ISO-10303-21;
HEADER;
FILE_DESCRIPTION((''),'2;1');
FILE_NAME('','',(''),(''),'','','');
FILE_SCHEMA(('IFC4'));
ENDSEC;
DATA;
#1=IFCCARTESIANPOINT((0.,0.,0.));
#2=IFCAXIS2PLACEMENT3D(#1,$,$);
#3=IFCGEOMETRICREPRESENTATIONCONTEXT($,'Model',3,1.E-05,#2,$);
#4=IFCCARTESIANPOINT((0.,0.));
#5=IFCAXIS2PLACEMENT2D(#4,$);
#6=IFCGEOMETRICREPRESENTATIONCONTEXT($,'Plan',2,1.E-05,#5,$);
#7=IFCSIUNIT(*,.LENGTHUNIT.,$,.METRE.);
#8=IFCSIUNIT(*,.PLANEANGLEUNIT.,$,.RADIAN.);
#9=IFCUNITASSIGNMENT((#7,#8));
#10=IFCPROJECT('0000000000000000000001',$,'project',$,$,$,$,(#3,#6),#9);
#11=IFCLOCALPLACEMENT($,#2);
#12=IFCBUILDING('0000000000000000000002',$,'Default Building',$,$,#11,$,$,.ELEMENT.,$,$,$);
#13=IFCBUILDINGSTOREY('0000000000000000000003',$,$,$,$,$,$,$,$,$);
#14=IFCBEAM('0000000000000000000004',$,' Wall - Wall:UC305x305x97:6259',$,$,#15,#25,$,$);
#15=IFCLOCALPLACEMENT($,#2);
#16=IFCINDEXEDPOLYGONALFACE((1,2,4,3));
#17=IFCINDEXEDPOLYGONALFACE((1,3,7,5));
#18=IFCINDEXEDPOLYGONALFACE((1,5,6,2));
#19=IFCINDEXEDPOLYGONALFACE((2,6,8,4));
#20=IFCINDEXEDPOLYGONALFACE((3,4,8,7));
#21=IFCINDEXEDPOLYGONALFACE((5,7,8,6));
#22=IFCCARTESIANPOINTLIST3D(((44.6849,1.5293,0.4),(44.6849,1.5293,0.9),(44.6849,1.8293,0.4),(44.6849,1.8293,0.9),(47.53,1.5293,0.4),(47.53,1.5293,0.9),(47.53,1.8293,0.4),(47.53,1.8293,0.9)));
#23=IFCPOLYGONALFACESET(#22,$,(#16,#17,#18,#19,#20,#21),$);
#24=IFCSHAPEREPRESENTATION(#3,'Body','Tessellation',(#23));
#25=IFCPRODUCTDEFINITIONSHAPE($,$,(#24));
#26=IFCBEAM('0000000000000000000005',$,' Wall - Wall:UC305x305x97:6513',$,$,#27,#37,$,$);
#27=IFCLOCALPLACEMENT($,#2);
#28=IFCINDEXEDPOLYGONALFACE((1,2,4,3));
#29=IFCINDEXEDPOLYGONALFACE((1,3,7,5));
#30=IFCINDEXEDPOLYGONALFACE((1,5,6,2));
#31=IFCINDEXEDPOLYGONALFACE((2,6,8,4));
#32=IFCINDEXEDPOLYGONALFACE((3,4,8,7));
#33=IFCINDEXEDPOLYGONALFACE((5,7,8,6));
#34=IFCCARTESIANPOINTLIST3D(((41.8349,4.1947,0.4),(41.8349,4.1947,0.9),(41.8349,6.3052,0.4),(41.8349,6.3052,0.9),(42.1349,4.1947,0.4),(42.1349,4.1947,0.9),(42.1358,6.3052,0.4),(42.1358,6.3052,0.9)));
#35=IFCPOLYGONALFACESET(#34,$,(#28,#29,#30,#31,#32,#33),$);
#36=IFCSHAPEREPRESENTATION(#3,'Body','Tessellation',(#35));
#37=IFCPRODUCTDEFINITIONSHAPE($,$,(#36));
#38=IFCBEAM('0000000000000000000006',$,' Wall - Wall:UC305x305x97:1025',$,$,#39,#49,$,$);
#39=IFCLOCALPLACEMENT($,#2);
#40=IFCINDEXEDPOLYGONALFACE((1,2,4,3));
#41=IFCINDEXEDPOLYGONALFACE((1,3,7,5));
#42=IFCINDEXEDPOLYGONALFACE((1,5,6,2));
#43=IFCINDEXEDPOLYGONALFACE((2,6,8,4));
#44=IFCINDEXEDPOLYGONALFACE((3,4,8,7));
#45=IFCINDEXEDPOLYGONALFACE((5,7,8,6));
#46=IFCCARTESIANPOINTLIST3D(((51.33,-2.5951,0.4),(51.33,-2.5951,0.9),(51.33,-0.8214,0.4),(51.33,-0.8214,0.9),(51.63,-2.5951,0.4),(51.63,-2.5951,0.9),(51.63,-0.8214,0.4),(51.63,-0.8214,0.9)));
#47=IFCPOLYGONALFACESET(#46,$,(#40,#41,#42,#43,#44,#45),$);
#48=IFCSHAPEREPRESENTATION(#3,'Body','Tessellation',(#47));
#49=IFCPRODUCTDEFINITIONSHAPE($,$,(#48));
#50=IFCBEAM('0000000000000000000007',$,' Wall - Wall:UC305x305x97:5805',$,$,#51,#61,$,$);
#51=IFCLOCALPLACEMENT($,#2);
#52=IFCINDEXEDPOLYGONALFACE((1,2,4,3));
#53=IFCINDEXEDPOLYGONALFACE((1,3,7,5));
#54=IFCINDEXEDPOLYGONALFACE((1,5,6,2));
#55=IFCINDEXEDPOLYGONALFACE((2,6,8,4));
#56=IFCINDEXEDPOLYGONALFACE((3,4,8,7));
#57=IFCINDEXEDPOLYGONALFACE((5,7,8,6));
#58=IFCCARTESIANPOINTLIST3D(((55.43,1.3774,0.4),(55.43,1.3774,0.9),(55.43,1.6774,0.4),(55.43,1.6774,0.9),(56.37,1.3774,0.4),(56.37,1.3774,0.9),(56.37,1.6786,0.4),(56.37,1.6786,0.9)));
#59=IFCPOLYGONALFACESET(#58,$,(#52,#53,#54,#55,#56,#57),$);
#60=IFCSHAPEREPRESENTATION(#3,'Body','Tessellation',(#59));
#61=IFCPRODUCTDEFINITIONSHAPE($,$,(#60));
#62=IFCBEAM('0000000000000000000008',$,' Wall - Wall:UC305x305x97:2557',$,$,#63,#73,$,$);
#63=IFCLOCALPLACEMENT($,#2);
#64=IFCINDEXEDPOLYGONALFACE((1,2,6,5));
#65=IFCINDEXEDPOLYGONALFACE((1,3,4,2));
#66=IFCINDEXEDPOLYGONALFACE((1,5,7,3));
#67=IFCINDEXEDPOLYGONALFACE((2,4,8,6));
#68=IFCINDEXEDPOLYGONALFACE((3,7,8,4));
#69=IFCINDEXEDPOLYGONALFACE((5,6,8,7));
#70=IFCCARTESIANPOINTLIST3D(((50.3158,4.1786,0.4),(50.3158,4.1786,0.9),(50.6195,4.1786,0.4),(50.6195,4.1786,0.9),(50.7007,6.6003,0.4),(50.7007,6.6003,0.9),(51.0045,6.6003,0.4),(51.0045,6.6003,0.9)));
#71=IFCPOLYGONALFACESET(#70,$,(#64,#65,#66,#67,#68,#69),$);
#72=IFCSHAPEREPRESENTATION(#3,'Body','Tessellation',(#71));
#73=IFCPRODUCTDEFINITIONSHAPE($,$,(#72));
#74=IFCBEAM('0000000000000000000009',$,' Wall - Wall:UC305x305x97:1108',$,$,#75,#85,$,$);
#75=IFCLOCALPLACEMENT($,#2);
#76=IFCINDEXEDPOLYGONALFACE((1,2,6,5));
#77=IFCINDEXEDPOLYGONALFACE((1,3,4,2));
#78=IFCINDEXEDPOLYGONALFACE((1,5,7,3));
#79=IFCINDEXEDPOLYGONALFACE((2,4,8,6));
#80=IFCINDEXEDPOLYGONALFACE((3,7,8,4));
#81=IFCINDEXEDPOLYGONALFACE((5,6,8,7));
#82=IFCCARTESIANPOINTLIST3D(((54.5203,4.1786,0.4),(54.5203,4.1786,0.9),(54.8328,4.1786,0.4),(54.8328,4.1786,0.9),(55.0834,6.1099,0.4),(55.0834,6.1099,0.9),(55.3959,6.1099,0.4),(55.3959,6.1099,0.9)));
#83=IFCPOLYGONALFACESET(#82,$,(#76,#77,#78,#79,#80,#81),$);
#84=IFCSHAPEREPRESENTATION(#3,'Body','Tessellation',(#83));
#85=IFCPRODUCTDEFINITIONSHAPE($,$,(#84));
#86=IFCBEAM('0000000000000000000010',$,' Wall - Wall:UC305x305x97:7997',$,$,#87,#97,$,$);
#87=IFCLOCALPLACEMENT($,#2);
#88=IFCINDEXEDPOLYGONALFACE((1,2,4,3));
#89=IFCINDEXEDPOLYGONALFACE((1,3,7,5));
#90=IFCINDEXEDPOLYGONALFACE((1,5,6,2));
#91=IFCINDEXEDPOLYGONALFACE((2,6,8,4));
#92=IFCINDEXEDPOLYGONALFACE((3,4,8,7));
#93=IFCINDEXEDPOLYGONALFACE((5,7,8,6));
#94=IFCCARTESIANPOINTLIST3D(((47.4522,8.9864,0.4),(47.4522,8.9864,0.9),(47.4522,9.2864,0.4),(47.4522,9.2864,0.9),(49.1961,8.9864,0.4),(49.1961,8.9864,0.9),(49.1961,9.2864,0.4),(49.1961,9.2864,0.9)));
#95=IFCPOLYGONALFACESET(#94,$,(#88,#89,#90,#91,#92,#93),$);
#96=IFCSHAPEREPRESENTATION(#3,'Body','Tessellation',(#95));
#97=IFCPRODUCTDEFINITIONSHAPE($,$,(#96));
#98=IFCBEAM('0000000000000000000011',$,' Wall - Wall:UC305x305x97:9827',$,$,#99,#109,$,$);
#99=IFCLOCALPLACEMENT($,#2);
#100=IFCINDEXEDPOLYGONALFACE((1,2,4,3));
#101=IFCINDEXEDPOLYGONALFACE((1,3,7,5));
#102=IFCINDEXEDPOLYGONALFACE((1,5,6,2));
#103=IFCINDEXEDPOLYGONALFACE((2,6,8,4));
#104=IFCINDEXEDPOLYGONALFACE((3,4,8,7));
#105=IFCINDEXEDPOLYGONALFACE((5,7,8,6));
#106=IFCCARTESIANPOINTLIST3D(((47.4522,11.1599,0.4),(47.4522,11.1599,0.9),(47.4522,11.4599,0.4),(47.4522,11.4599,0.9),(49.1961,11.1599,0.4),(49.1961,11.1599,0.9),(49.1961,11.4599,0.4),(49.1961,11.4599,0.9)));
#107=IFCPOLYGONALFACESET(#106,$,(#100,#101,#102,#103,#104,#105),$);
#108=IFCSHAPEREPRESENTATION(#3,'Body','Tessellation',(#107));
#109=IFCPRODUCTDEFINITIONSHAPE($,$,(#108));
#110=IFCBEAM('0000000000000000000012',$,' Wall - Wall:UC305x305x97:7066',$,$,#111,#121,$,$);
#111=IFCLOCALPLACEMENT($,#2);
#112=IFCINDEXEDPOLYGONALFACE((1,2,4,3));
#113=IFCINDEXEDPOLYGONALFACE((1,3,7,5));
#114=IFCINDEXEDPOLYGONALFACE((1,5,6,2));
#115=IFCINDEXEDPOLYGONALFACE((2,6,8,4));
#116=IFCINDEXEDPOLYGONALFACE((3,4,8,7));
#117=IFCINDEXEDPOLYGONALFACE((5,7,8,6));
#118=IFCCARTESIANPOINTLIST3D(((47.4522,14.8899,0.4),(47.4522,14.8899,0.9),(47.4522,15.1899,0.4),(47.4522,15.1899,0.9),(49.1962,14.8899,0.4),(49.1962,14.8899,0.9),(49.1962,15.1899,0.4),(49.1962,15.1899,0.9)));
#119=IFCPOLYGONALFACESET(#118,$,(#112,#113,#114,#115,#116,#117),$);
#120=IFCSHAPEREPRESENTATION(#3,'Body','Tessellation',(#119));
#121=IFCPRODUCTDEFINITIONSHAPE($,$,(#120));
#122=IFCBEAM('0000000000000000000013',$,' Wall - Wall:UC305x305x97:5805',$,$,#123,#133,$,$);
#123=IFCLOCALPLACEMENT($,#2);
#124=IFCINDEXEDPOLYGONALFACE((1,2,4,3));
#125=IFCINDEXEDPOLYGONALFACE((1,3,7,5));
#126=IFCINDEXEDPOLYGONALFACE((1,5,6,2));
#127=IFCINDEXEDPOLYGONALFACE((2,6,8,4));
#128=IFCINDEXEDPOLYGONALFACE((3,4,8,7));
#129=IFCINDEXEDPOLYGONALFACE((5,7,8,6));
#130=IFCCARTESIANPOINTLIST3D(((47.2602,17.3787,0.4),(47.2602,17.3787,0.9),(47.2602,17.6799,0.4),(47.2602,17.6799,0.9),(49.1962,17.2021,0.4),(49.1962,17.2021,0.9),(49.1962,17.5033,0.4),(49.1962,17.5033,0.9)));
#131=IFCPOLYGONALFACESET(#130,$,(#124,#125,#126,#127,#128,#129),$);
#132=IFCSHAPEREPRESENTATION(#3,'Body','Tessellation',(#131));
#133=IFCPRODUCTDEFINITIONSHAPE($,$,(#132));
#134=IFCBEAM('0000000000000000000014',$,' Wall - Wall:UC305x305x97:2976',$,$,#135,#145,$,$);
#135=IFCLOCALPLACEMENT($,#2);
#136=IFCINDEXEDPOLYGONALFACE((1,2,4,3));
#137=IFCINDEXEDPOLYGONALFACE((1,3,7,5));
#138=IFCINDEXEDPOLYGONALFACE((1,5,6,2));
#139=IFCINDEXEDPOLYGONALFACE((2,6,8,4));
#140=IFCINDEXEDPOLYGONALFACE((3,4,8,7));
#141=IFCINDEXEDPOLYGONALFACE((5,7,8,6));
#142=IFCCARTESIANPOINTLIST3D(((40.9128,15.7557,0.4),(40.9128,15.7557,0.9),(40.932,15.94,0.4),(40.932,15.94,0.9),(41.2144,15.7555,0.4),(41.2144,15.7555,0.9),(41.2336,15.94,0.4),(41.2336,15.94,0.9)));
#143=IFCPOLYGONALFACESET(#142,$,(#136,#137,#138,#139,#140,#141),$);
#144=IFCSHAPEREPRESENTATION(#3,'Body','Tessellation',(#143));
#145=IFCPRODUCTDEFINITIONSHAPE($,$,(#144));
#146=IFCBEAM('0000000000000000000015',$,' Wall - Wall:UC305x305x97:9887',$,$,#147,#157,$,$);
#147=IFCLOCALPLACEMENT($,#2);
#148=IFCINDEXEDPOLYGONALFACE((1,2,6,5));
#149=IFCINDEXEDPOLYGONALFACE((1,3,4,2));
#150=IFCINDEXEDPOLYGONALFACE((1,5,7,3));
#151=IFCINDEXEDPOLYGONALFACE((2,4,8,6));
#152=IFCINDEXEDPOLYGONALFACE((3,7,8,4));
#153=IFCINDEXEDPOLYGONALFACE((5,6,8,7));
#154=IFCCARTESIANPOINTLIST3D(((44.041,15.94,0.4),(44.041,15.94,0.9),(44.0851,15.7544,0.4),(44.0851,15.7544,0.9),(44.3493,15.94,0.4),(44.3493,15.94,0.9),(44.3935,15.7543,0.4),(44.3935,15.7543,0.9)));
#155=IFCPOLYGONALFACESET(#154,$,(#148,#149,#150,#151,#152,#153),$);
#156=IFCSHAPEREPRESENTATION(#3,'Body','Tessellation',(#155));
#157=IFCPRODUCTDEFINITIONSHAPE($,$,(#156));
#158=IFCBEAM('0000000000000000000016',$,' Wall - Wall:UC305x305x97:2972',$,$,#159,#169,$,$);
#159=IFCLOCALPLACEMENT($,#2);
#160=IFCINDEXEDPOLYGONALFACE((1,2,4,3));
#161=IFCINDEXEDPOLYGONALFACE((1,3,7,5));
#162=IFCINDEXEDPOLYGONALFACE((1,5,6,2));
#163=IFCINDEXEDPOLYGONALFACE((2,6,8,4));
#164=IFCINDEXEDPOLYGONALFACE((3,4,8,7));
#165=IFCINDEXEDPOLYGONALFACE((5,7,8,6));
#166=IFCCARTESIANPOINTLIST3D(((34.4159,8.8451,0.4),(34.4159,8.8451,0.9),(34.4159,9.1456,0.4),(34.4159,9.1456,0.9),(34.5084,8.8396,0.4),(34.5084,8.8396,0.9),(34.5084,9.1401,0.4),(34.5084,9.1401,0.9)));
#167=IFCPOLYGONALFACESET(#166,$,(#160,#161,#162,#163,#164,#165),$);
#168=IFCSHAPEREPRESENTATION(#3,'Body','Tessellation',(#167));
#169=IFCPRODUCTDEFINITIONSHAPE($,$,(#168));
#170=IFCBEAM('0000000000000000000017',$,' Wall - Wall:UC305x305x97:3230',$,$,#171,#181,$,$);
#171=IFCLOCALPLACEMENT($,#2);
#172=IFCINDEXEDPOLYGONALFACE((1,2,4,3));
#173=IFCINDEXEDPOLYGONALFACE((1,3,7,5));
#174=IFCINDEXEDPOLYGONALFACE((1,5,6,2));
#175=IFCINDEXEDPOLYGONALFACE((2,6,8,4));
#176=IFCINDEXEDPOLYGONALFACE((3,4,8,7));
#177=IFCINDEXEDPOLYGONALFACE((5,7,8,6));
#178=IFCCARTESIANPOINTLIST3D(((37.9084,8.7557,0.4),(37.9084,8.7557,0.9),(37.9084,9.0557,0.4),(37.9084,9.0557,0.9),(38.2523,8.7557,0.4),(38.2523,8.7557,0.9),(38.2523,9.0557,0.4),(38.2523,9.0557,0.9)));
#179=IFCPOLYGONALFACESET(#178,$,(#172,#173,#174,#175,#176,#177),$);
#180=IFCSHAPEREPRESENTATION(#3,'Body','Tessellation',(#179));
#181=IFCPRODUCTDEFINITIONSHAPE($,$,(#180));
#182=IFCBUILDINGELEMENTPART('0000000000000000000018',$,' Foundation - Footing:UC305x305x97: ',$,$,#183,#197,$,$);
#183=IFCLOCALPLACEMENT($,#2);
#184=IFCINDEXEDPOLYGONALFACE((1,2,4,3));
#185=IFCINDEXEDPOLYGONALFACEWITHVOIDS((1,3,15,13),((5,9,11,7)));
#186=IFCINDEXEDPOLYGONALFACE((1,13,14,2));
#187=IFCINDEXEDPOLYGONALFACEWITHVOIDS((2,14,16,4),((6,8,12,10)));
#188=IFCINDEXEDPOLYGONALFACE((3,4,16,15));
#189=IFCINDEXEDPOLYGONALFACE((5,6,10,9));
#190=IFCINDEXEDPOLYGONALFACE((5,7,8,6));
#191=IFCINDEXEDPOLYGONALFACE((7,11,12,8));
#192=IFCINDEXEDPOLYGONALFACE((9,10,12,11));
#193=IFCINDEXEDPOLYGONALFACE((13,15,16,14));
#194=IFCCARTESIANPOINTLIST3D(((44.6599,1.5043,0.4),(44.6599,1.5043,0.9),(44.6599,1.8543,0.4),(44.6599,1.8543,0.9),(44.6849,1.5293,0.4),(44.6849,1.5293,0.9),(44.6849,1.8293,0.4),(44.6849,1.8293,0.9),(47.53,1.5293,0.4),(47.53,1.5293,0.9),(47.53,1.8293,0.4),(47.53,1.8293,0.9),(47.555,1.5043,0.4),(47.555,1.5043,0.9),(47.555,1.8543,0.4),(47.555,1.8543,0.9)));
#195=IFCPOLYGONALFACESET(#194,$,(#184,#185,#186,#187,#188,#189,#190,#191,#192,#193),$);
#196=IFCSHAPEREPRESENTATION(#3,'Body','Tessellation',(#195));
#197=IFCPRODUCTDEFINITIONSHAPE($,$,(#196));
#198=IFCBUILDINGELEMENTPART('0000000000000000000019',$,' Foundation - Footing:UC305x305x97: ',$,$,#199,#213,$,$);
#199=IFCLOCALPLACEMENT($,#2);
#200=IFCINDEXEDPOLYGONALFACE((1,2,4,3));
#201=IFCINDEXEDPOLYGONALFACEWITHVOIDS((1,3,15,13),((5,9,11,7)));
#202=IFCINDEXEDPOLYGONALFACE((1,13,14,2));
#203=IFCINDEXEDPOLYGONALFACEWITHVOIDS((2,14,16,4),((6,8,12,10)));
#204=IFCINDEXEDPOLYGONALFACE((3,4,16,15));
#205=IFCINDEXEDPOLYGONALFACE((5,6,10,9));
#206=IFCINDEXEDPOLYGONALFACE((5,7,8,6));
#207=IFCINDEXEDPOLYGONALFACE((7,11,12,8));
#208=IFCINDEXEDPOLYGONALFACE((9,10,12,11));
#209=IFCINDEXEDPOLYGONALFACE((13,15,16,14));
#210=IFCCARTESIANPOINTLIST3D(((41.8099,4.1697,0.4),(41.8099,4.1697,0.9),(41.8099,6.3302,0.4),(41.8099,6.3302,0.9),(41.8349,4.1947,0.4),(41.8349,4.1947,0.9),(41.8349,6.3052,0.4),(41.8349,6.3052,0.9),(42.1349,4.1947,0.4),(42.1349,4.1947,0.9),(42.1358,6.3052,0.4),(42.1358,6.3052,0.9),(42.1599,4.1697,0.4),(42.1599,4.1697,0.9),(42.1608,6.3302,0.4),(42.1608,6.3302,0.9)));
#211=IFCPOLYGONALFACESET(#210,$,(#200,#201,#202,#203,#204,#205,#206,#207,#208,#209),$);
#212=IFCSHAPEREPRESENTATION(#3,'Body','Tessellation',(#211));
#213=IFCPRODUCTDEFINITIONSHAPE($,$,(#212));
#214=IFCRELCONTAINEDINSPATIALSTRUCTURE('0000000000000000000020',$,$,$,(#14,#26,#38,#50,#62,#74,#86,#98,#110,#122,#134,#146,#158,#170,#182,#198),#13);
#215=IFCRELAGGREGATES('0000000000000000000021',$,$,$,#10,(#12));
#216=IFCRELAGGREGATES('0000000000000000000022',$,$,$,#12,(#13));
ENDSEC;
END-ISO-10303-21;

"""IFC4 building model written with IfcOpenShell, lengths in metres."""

from ifc_helpers import new_model, si_unit, origin, origin_2d, place, context, project, spatial, polyline, outline, extrude, element, save


model = new_model("IFC4")

# Units and contexts
model_context = context("Model", 3, precision=1e-05, world=origin())
plan_context = context("Plan", 2, precision=1e-05, world=origin_2d())
ifc_project = project(units=[si_unit("LENGTHUNIT", "METRE"), si_unit("PLANEANGLEUNIT", "RADIAN")], contexts=[model_context, plan_context])

# Building, storey
building_placement = place(None, origin())
building = spatial("IfcBuilding", under=ifc_project, at=building_placement, Name="Default Building", CompositionType="ELEMENT")
storey = spatial("IfcBuildingStorey", under=building)

# Beams
element("IfcBeam", 1, inside=storey, Name=" Wall - Wall:UC305x305x97:6259", context=model_context, shape_type="SweptSolid", body=[
    extrude(outline(polyline([(44.6849, 1.5293, 0.4), (44.6849, 1.8293, 0.4), (47.53, 1.8293, 0.4), (47.53, 1.5293, 0.4), (44.6849, 1.5293, 0.4)])), None, (0.0, 0.0, 1.0), 0.5),
])
element("IfcBeam", 2, inside=storey, Name=" Wall - Wall:UC305x305x97:6513", context=model_context, shape_type="SweptSolid", body=[
    extrude(outline(polyline([(41.8349, 4.1947, 0.4), (42.1349, 4.1947, 0.4), (42.1358, 6.3052, 0.4), (41.8349, 6.3052, 0.4), (41.8349, 4.1947, 0.4)])), None, (0.0, 0.0, 1.0), 0.5),
])
element("IfcBeam", 3, inside=storey, Name=" Wall - Wall:UC305x305x97:1025", context=model_context, shape_type="SweptSolid", body=[
    extrude(outline(polyline([(51.33, -2.5951, 0.4), (51.63, -2.5951, 0.4), (51.63, -0.8214, 0.4), (51.33, -0.8214, 0.4), (51.33, -2.5951, 0.4)])), None, (0.0, 0.0, 1.0), 0.5),
])
element("IfcBeam", 4, inside=storey, Name=" Wall - Wall:UC305x305x97:5805", context=model_context, shape_type="SweptSolid", body=[
    extrude(outline(polyline([(55.43, 1.3774, 0.4), (55.43, 1.6774, 0.4), (56.37, 1.6786, 0.4), (56.37, 1.3774, 0.4), (55.43, 1.3774, 0.4)])), None, (0.0, 0.0, 1.0), 0.5),
])
element("IfcBeam", 5, inside=storey, Name=" Wall - Wall:UC305x305x97:2557", context=model_context, shape_type="SweptSolid", body=[
    extrude(outline(polyline([(50.3158, 4.1786, 0.4), (50.7007, 6.6003, 0.4), (51.0045, 6.6003, 0.4), (50.6195, 4.1786, 0.4), (50.3158, 4.1786, 0.4)])), None, (0.0, 0.0, 1.0), 0.5),
])
element("IfcBeam", 6, inside=storey, Name=" Wall - Wall:UC305x305x97:1108", context=model_context, shape_type="SweptSolid", body=[
    extrude(outline(polyline([(54.8328, 4.1786, 0.4), (54.5203, 4.1786, 0.4), (55.0834, 6.1099, 0.4), (55.3959, 6.1099, 0.4), (54.8328, 4.1786, 0.4)])), None, (0.0, 0.0, 1.0), 0.5),
])
element("IfcBeam", 7, inside=storey, Name=" Wall - Wall:UC305x305x97:7997", context=model_context, shape_type="SweptSolid", body=[
    extrude(outline(polyline([(47.4522, 8.9864, 0.4), (49.1961, 8.9864, 0.4), (49.1961, 9.2864, 0.4), (47.4522, 9.2864, 0.4), (47.4522, 8.9864, 0.4)])), None, (0.0, 0.0, 1.0), 0.5),
])
element("IfcBeam", 8, inside=storey, Name=" Wall - Wall:UC305x305x97:9827", context=model_context, shape_type="SweptSolid", body=[
    extrude(outline(polyline([(47.4522, 11.1599, 0.4), (47.4522, 11.4599, 0.4), (49.1961, 11.4599, 0.4), (49.1961, 11.1599, 0.4), (47.4522, 11.1599, 0.4)])), None, (0.0, 0.0, 1.0), 0.5),
])
element("IfcBeam", 9, inside=storey, Name=" Wall - Wall:UC305x305x97:7066", context=model_context, shape_type="SweptSolid", body=[
    extrude(outline(polyline([(47.4522, 14.8899, 0.4), (47.4522, 15.1899, 0.4), (49.1962, 15.1899, 0.4), (49.1962, 14.8899, 0.4), (47.4522, 14.8899, 0.4)])), None, (0.0, 0.0, 1.0), 0.5),
])
element("IfcBeam", 10, inside=storey, Name=" Wall - Wall:UC305x305x97:5805", context=model_context, shape_type="SweptSolid", body=[
    extrude(outline(polyline([(47.2602, 17.3787, 0.4), (47.2602, 17.6799, 0.4), (49.1962, 17.5033, 0.4), (49.1962, 17.2021, 0.4), (47.2602, 17.3787, 0.4)])), None, (0.0, 0.0, 1.0), 0.5),
])
element("IfcBeam", 11, inside=storey, Name=" Wall - Wall:UC305x305x97:2976", context=model_context, shape_type="SweptSolid", body=[
    extrude(outline(polyline([(40.9128, 15.7557, 0.4), (40.932, 15.94, 0.4), (41.2336, 15.94, 0.4), (41.2144, 15.7555, 0.4), (40.9128, 15.7557, 0.4)])), None, (0.0, 0.0, 1.0), 0.5),
])
element("IfcBeam", 12, inside=storey, Name=" Wall - Wall:UC305x305x97:9887", context=model_context, shape_type="SweptSolid", body=[
    extrude(outline(polyline([(44.0851, 15.7544, 0.4), (44.041, 15.94, 0.4), (44.3493, 15.94, 0.4), (44.3935, 15.7543, 0.4), (44.0851, 15.7544, 0.4)])), None, (0.0, 0.0, 1.0), 0.5),
])
element("IfcBeam", 13, inside=storey, Name=" Wall - Wall:UC305x305x97:2972", context=model_context, shape_type="SweptSolid", body=[
    extrude(outline(polyline([(34.4159, 8.8451, 0.4), (34.5084, 8.8396, 0.4), (34.5084, 9.1401, 0.4), (34.4159, 9.1456, 0.4), (34.4159, 8.8451, 0.4)])), None, (0.0, 0.0, 1.0), 0.5),
])
element("IfcBeam", 14, inside=storey, Name=" Wall - Wall:UC305x305x97:3230", context=model_context, shape_type="SweptSolid", body=[
    extrude(outline(polyline([(37.9084, 8.7557, 0.4), (38.2523, 8.7557, 0.4), (38.2523, 9.0557, 0.4), (37.9084, 9.0557, 0.4), (37.9084, 8.7557, 0.4)])), None, (0.0, 0.0, 1.0), 0.5),
])

# Building element parts, openings
building_element_part_1 = element("IfcBuildingElementPart", 15, inside=storey, Name=" Foundation - Footing:UC305x305x97: ", context=model_context, shape_type="SweptSolid", body=[
    extrude(outline(polyline([(44.6599, 1.5043, 0.4), (44.6599, 1.8543, 0.4), (47.555, 1.8543, 0.4), (47.555, 1.5043, 0.4), (44.6599, 1.5043, 0.4)])), None, (0.0, 0.0, 1.0), 0.5),
])
element("IfcOpeningElement", 16, inside=storey, cuts=building_element_part_1, context=model_context, shape_type="SweptSolid", body=[
    extrude(outline(polyline([(44.6849, 1.5293, 0.4), (44.6849, 1.8293, 0.4), (47.53, 1.8293, 0.4), (47.53, 1.5293, 0.4), (44.6849, 1.5293, 0.4)])), None, (0.0, 0.0, 1.0), 0.5),
])
building_element_part_2 = element("IfcBuildingElementPart", 17, inside=storey, Name=" Foundation - Footing:UC305x305x97: ", context=model_context, shape_type="SweptSolid", body=[
    extrude(outline(polyline([(41.8099, 4.1697, 0.4), (42.1599, 4.1697, 0.4), (42.1608, 6.3302, 0.4), (41.8099, 6.3302, 0.4), (41.8099, 4.1697, 0.4)])), None, (0.0, 0.0, 1.0), 0.5),
])
element("IfcOpeningElement", 18, inside=storey, cuts=building_element_part_2, context=model_context, shape_type="SweptSolid", body=[
    extrude(outline(polyline([(41.8349, 4.1947, 0.4), (42.1349, 4.1947, 0.4), (42.1358, 6.3052, 0.4), (41.8349, 6.3052, 0.4), (41.8349, 4.1947, 0.4)])), None, (0.0, 0.0, 1.0), 0.5),
])

save(model, "model.ifc")
